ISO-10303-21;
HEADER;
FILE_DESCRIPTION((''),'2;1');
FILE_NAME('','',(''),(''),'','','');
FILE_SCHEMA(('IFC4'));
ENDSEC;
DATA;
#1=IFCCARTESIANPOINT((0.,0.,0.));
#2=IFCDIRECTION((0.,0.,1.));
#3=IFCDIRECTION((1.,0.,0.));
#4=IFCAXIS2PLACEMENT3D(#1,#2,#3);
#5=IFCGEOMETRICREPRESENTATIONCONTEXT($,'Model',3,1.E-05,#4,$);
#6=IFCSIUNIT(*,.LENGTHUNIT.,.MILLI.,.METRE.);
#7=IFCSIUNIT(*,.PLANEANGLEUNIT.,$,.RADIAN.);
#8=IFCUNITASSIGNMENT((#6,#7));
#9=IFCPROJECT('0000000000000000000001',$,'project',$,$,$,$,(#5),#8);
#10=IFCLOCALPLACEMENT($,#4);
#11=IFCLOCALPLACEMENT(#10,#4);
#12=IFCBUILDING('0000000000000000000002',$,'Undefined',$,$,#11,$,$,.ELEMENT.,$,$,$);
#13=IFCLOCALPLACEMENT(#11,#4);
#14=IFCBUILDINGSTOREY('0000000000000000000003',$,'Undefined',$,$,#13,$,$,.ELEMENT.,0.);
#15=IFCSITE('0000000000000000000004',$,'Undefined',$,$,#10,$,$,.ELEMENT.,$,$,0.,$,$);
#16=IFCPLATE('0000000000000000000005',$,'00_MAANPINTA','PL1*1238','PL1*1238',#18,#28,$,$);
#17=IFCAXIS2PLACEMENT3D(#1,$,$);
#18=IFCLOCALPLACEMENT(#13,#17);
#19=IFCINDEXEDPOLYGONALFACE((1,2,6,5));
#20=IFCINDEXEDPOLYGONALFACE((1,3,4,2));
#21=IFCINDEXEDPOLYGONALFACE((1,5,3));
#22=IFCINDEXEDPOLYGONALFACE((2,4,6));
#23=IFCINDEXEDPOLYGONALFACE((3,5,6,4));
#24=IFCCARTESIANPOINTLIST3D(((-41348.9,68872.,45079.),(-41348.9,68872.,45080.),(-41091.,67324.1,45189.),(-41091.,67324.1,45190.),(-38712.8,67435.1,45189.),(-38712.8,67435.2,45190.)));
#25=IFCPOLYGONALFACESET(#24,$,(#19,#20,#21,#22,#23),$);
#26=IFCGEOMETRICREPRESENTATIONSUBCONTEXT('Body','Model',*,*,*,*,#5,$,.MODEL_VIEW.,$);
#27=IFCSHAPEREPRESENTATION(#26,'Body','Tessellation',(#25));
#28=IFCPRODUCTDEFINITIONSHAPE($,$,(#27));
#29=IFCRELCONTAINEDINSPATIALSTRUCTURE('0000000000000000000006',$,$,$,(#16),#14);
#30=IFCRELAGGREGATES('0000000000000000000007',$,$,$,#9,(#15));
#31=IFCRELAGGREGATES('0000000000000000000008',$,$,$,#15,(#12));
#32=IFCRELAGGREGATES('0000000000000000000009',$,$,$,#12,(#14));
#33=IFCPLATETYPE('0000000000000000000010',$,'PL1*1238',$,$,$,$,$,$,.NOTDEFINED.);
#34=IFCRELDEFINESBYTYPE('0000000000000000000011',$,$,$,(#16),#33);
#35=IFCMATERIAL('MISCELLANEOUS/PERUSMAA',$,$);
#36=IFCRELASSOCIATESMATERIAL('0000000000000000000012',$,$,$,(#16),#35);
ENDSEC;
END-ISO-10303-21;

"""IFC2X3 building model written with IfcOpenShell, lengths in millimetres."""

from ifc_helpers import new_model, si_unit, frame, origin_with_axes, place, context, subcontext, project, spatial, polyline, outline, extrude, material, type_object, element, save


model = new_model("IFC2X3")

# Units and contexts
model_context = context("Model", 3, precision=1e-05, world=origin_with_axes())
body_context = subcontext(model_context, "Body", "Model", "MODEL_VIEW")
ifc_project = project(units=[si_unit("LENGTHUNIT", "METRE", prefix="MILLI"), si_unit("PLANEANGLEUNIT", "RADIAN")], contexts=[model_context])

# Site, building, storey
site_placement = place(None, origin_with_axes())
site = spatial("IfcSite", under=ifc_project, at=site_placement, Name="Undefined", CompositionType="ELEMENT", RefElevation=0.0)
building_placement = place(site_placement, origin_with_axes())
building = spatial("IfcBuilding", under=site, at=building_placement, Name="Undefined", CompositionType="ELEMENT")
storey_placement = place(building_placement, origin_with_axes())
storey = spatial("IfcBuildingStorey", under=building, at=storey_placement, Name="Undefined", CompositionType="ELEMENT", Elevation=0.0)

# Plate
ifc_material = material(Name="MISCELLANEOUS/PERUSMAA")
plate_type_1 = type_object("IfcPlateType", Name="PL1*1238", PredefinedType="NOTDEFINED")
plate_1_placement = place(storey_placement, frame((-38712.8, 67435.2, 45189.5), z_axis=(0.003285, -0.07034, -0.997518), x_axis=(-0.998911, -0.046658, 0.0)))
element("IfcPlate", 1, at=plate_1_placement, inside=storey, type_object=plate_type_1, material=ifc_material, Name="00_MAANPINTA", Description="PL1*1238", ObjectType="PL1*1238", context=body_context, shape_type="SweptSolid", body=[
    extrude(outline(polyline([(0.0, 0.0), (2380.8, 0.0), (2566.2, 1562.1), (0.0, 0.0)])), frame((0.0, 0.0, -0.5), z_axis=(0.0, 0.0, 1.0), x_axis=(1.0, 0.0, 0.0)), (0.0, 0.0, 1.0), 1.0),
])

save(model, "model.ifc")
